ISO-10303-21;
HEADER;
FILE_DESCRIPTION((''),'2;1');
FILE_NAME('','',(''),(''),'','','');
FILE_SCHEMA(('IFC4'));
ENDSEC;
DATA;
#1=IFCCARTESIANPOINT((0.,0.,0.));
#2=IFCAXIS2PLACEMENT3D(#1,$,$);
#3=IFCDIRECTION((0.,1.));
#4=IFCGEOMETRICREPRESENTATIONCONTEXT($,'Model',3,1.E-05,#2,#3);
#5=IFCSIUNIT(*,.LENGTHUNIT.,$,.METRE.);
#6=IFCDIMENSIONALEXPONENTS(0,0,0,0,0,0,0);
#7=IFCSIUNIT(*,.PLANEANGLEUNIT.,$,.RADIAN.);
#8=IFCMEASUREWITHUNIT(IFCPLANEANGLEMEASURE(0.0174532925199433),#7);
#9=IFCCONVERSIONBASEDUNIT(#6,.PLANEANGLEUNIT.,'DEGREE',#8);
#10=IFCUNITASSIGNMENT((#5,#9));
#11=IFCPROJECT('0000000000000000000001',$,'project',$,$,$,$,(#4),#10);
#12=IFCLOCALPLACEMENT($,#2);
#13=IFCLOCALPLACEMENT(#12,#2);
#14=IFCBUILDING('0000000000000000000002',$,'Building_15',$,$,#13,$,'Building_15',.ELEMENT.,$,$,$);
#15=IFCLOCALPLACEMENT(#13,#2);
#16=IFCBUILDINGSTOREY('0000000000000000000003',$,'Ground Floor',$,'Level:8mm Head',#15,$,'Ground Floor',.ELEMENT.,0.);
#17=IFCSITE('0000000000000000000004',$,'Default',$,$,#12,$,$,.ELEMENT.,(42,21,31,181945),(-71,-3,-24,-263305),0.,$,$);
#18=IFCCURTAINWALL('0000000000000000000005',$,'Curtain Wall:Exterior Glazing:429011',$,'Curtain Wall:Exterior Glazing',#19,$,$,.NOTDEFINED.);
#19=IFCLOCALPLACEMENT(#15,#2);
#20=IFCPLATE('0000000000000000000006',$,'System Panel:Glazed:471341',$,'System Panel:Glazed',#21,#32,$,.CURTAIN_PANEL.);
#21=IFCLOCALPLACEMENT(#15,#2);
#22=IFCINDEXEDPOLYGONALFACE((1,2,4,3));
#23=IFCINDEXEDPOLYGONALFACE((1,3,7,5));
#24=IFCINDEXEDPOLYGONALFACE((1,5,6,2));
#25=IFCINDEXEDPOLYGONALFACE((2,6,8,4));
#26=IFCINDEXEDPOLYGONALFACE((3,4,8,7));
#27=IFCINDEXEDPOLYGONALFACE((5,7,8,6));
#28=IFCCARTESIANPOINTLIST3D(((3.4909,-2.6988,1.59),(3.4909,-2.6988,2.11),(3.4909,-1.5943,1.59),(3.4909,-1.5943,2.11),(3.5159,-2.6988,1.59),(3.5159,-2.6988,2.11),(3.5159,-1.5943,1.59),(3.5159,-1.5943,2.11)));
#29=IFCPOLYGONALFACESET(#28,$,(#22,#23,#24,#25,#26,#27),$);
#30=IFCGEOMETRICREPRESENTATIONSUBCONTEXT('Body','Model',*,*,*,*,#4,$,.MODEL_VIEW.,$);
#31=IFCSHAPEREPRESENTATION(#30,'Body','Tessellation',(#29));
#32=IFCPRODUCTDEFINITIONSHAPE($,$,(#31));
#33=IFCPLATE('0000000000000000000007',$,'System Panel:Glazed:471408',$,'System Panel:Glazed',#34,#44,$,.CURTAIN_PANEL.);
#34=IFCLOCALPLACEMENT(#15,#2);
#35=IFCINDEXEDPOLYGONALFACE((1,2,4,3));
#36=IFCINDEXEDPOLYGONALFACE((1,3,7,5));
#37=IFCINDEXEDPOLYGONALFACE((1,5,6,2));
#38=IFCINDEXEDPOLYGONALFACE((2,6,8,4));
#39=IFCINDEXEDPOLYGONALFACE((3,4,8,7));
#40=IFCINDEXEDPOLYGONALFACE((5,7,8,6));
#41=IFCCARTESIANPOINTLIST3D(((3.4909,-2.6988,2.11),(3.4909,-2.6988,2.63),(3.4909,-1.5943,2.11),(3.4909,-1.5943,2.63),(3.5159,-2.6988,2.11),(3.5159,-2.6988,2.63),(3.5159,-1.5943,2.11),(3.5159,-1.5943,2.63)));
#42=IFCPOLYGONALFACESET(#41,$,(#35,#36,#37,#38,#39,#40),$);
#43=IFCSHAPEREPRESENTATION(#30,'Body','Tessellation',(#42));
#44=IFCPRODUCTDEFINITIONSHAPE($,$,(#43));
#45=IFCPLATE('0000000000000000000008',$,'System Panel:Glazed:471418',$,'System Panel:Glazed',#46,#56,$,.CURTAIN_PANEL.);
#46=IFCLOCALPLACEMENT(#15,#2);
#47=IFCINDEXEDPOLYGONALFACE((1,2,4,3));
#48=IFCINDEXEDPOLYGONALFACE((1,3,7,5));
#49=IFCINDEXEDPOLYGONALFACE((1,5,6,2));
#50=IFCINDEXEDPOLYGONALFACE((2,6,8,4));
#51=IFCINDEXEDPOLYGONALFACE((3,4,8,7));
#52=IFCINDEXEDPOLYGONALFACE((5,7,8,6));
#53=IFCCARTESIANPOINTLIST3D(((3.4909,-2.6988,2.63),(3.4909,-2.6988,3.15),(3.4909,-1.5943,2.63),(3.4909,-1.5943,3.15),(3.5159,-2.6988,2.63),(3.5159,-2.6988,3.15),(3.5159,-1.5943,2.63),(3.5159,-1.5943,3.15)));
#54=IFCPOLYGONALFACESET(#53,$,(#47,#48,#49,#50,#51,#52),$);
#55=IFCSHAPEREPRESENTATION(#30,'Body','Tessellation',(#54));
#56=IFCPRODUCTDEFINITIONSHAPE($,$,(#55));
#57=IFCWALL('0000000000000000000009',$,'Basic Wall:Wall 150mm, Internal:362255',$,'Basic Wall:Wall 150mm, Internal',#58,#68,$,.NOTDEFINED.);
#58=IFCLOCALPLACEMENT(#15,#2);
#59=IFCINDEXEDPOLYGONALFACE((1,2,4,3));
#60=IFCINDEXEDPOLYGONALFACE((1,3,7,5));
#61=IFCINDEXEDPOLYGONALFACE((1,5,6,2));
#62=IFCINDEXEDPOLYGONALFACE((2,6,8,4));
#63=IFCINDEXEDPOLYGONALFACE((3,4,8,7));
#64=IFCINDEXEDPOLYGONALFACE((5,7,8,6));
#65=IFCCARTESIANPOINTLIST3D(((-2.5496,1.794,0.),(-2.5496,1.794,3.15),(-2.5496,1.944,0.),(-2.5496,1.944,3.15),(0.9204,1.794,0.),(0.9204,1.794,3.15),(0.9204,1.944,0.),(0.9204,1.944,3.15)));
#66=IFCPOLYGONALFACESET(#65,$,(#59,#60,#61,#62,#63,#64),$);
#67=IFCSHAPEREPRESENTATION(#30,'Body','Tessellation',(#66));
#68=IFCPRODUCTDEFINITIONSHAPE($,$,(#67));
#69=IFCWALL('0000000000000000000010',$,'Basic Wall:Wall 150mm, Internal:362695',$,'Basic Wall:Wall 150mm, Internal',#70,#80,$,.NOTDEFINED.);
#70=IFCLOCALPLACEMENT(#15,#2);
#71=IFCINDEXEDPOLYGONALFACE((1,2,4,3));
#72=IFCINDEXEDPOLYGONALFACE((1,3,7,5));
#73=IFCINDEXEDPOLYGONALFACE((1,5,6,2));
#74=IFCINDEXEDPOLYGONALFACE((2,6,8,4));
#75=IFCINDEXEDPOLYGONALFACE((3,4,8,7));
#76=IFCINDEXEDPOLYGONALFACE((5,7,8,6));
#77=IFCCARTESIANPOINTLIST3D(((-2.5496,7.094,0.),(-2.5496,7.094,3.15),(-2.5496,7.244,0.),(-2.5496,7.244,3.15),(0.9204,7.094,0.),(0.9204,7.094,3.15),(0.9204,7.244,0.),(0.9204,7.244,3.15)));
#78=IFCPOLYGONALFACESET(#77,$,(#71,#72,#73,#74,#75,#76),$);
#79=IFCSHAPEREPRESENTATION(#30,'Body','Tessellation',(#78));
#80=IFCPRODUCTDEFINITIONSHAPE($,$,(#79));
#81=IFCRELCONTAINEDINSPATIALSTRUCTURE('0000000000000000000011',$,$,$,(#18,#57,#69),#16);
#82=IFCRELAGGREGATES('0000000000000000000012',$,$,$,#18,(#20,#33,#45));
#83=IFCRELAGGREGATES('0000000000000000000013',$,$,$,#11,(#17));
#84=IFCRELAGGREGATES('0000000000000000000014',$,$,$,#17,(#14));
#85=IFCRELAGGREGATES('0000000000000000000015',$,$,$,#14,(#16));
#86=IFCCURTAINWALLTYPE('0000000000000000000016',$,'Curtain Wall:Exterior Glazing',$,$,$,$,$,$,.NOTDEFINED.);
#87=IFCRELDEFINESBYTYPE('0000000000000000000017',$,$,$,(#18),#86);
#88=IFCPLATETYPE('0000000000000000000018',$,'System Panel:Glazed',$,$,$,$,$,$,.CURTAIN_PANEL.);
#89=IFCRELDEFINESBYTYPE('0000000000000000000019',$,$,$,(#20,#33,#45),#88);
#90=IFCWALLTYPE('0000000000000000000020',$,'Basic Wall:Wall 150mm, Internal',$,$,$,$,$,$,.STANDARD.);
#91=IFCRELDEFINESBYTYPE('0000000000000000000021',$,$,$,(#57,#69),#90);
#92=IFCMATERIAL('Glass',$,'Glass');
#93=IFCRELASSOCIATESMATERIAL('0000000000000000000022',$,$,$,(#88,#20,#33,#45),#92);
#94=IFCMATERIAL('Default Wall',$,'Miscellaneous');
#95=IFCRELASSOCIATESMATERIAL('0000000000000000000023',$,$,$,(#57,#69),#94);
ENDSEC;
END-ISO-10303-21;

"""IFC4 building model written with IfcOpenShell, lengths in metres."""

from ifc_helpers import new_model, entity, si_unit, converted_unit, direction, frame, origin, place, context, subcontext, project, spatial, indexed_curve, outline, extrude, source, transform, mapped, material, type_object, type_shapes, element, aggregate, save


model = new_model("IFC4")

# Units and contexts
model_context = context("Model", 3, precision=1e-05, world=origin(), true_north=direction((0.0, 1.0)))
body_context = subcontext(model_context, "Body", "Model", "MODEL_VIEW")
ifc_project = project(units=[si_unit("LENGTHUNIT", "METRE"), converted_unit("PLANEANGLEUNIT", "DEGREE", entity("IfcPlaneAngleMeasure", 0.0174532925199433), si_unit("PLANEANGLEUNIT", "RADIAN"), dimensions=[0, 0, 0, 0, 0, 0, 0])], contexts=[model_context])

# Site, building, storey
site_placement = place(None, origin())
site = spatial("IfcSite", under=ifc_project, at=site_placement, Name="Default", CompositionType="ELEMENT", RefLatitude=(42, 21, 31, 181945), RefLongitude=(-71, -3, -24, -263305), RefElevation=0.0)
building_placement = place(site_placement, origin())
building = spatial("IfcBuilding", under=site, at=building_placement, Name="Building_15", LongName="Building_15", CompositionType="ELEMENT")
storey_placement = place(building_placement, origin())
storey = spatial("IfcBuildingStorey", under=building, at=storey_placement, Name="Ground Floor", ObjectType="Level:8mm Head", LongName="Ground Floor", CompositionType="ELEMENT", Elevation=0.0)

# Curtain wall, plates
curtain_wall_type = type_object("IfcCurtainWallType", Name="Curtain Wall:Exterior Glazing", PredefinedType="NOTDEFINED")
curtain_wall_placement = place(storey_placement, origin())
curtain_wall = element("IfcCurtainWall", 1, at=curtain_wall_placement, inside=storey, type_object=curtain_wall_type, Name="Curtain Wall:Exterior Glazing:429011", ObjectType="Curtain Wall:Exterior Glazing", PredefinedType="NOTDEFINED")
ifc_material_1 = material(Name="Glass", Category="Glass")
plate_type_1 = type_object("IfcPlateType", Name="System Panel:Glazed", PredefinedType="CURTAIN_PANEL", material=ifc_material_1)
shared_shape_1 = source(origin(), body_context, "Body", "SweptSolid", [
    extrude(outline(indexed_curve([(-0.0125, -0.5522), (0.0125, -0.5522), (0.0125, 0.5522), (-0.0125, 0.5522), (-0.0125, -0.5522)], self_intersect=False)), frame((0.0, 0.037, 0.0), z_axis=(0.0, 0.0, 1.0), x_axis=(0.0, 1.0, 0.0)), (0.0, 0.0, 1.0), 0.52),
])
type_shapes(plate_type_1, [shared_shape_1])
plate_1_placement = place(curtain_wall_placement, frame((3.5404, -2.1466, 1.59), z_axis=(0.0, 0.0, 1.0), x_axis=(0.0, 1.0, 0.0)))
plate_1 = element("IfcPlate", 2, at=plate_1_placement, type_object=plate_type_1, material=ifc_material_1, Name="System Panel:Glazed:471341", ObjectType="System Panel:Glazed", PredefinedType="CURTAIN_PANEL", context=body_context, shape_type="MappedRepresentation", body=[
    mapped(shared_shape_1, transform((0.0, 0.0, 0.0), scale=1.0)),
])
plate_2_placement = place(curtain_wall_placement, frame((3.5404, -2.1466, 2.11), z_axis=(0.0, 0.0, 1.0), x_axis=(0.0, 1.0, 0.0)))
plate_2 = element("IfcPlate", 3, at=plate_2_placement, type_object=plate_type_1, material=ifc_material_1, Name="System Panel:Glazed:471408", ObjectType="System Panel:Glazed", PredefinedType="CURTAIN_PANEL", context=body_context, shape_type="MappedRepresentation", body=[
    mapped(shared_shape_1, transform((0.0, 0.0, 0.0), scale=1.0)),
])
plate_3_placement = place(curtain_wall_placement, frame((3.5404, -2.1466, 2.63), z_axis=(0.0, 0.0, 1.0), x_axis=(0.0, 1.0, 0.0)))
plate_3 = element("IfcPlate", 4, at=plate_3_placement, type_object=plate_type_1, material=ifc_material_1, Name="System Panel:Glazed:471418", ObjectType="System Panel:Glazed", PredefinedType="CURTAIN_PANEL", context=body_context, shape_type="MappedRepresentation", body=[
    mapped(shared_shape_1, transform((0.0, 0.0, 0.0), scale=1.0)),
])
aggregate(curtain_wall, [plate_1, plate_2, plate_3])

# Walls
ifc_material_2 = material(Name="Default Wall", Category="Miscellaneous")
wall_type = type_object("IfcWallType", Name="Basic Wall:Wall 150mm, Internal", PredefinedType="STANDARD")
wall_1_placement = place(storey_placement, frame((0.9204, 1.869, 0.0), z_axis=(0.0, 0.0, 1.0), x_axis=(-1.0, 0.0, 0.0)))
element("IfcWall", 5, at=wall_1_placement, inside=storey, type_object=wall_type, material=ifc_material_2, Name="Basic Wall:Wall 150mm, Internal:362255", ObjectType="Basic Wall:Wall 150mm, Internal", PredefinedType="NOTDEFINED", context=body_context, shape_type="SweptSolid", body=[
    extrude(outline(indexed_curve([(3.47, 0.075), (0.0, 0.075), (0.0, -0.075), (3.47, -0.075), (3.47, 0.075)], self_intersect=False)), origin(), (0.0, 0.0, 1.0), 3.15),
])
wall_2_placement = place(storey_placement, frame((0.9204, 7.169, 0.0), z_axis=(0.0, 0.0, 1.0), x_axis=(-1.0, 0.0, 0.0)))
element("IfcWall", 6, at=wall_2_placement, inside=storey, type_object=wall_type, material=ifc_material_2, Name="Basic Wall:Wall 150mm, Internal:362695", ObjectType="Basic Wall:Wall 150mm, Internal", PredefinedType="NOTDEFINED", context=body_context, shape_type="SweptSolid", body=[
    extrude(outline(indexed_curve([(3.47, 0.075), (0.0, 0.075), (0.0, -0.075), (3.47, -0.075), (3.47, 0.075)], self_intersect=False)), origin(), (0.0, 0.0, 1.0), 3.15),
])

save(model, "model.ifc")
